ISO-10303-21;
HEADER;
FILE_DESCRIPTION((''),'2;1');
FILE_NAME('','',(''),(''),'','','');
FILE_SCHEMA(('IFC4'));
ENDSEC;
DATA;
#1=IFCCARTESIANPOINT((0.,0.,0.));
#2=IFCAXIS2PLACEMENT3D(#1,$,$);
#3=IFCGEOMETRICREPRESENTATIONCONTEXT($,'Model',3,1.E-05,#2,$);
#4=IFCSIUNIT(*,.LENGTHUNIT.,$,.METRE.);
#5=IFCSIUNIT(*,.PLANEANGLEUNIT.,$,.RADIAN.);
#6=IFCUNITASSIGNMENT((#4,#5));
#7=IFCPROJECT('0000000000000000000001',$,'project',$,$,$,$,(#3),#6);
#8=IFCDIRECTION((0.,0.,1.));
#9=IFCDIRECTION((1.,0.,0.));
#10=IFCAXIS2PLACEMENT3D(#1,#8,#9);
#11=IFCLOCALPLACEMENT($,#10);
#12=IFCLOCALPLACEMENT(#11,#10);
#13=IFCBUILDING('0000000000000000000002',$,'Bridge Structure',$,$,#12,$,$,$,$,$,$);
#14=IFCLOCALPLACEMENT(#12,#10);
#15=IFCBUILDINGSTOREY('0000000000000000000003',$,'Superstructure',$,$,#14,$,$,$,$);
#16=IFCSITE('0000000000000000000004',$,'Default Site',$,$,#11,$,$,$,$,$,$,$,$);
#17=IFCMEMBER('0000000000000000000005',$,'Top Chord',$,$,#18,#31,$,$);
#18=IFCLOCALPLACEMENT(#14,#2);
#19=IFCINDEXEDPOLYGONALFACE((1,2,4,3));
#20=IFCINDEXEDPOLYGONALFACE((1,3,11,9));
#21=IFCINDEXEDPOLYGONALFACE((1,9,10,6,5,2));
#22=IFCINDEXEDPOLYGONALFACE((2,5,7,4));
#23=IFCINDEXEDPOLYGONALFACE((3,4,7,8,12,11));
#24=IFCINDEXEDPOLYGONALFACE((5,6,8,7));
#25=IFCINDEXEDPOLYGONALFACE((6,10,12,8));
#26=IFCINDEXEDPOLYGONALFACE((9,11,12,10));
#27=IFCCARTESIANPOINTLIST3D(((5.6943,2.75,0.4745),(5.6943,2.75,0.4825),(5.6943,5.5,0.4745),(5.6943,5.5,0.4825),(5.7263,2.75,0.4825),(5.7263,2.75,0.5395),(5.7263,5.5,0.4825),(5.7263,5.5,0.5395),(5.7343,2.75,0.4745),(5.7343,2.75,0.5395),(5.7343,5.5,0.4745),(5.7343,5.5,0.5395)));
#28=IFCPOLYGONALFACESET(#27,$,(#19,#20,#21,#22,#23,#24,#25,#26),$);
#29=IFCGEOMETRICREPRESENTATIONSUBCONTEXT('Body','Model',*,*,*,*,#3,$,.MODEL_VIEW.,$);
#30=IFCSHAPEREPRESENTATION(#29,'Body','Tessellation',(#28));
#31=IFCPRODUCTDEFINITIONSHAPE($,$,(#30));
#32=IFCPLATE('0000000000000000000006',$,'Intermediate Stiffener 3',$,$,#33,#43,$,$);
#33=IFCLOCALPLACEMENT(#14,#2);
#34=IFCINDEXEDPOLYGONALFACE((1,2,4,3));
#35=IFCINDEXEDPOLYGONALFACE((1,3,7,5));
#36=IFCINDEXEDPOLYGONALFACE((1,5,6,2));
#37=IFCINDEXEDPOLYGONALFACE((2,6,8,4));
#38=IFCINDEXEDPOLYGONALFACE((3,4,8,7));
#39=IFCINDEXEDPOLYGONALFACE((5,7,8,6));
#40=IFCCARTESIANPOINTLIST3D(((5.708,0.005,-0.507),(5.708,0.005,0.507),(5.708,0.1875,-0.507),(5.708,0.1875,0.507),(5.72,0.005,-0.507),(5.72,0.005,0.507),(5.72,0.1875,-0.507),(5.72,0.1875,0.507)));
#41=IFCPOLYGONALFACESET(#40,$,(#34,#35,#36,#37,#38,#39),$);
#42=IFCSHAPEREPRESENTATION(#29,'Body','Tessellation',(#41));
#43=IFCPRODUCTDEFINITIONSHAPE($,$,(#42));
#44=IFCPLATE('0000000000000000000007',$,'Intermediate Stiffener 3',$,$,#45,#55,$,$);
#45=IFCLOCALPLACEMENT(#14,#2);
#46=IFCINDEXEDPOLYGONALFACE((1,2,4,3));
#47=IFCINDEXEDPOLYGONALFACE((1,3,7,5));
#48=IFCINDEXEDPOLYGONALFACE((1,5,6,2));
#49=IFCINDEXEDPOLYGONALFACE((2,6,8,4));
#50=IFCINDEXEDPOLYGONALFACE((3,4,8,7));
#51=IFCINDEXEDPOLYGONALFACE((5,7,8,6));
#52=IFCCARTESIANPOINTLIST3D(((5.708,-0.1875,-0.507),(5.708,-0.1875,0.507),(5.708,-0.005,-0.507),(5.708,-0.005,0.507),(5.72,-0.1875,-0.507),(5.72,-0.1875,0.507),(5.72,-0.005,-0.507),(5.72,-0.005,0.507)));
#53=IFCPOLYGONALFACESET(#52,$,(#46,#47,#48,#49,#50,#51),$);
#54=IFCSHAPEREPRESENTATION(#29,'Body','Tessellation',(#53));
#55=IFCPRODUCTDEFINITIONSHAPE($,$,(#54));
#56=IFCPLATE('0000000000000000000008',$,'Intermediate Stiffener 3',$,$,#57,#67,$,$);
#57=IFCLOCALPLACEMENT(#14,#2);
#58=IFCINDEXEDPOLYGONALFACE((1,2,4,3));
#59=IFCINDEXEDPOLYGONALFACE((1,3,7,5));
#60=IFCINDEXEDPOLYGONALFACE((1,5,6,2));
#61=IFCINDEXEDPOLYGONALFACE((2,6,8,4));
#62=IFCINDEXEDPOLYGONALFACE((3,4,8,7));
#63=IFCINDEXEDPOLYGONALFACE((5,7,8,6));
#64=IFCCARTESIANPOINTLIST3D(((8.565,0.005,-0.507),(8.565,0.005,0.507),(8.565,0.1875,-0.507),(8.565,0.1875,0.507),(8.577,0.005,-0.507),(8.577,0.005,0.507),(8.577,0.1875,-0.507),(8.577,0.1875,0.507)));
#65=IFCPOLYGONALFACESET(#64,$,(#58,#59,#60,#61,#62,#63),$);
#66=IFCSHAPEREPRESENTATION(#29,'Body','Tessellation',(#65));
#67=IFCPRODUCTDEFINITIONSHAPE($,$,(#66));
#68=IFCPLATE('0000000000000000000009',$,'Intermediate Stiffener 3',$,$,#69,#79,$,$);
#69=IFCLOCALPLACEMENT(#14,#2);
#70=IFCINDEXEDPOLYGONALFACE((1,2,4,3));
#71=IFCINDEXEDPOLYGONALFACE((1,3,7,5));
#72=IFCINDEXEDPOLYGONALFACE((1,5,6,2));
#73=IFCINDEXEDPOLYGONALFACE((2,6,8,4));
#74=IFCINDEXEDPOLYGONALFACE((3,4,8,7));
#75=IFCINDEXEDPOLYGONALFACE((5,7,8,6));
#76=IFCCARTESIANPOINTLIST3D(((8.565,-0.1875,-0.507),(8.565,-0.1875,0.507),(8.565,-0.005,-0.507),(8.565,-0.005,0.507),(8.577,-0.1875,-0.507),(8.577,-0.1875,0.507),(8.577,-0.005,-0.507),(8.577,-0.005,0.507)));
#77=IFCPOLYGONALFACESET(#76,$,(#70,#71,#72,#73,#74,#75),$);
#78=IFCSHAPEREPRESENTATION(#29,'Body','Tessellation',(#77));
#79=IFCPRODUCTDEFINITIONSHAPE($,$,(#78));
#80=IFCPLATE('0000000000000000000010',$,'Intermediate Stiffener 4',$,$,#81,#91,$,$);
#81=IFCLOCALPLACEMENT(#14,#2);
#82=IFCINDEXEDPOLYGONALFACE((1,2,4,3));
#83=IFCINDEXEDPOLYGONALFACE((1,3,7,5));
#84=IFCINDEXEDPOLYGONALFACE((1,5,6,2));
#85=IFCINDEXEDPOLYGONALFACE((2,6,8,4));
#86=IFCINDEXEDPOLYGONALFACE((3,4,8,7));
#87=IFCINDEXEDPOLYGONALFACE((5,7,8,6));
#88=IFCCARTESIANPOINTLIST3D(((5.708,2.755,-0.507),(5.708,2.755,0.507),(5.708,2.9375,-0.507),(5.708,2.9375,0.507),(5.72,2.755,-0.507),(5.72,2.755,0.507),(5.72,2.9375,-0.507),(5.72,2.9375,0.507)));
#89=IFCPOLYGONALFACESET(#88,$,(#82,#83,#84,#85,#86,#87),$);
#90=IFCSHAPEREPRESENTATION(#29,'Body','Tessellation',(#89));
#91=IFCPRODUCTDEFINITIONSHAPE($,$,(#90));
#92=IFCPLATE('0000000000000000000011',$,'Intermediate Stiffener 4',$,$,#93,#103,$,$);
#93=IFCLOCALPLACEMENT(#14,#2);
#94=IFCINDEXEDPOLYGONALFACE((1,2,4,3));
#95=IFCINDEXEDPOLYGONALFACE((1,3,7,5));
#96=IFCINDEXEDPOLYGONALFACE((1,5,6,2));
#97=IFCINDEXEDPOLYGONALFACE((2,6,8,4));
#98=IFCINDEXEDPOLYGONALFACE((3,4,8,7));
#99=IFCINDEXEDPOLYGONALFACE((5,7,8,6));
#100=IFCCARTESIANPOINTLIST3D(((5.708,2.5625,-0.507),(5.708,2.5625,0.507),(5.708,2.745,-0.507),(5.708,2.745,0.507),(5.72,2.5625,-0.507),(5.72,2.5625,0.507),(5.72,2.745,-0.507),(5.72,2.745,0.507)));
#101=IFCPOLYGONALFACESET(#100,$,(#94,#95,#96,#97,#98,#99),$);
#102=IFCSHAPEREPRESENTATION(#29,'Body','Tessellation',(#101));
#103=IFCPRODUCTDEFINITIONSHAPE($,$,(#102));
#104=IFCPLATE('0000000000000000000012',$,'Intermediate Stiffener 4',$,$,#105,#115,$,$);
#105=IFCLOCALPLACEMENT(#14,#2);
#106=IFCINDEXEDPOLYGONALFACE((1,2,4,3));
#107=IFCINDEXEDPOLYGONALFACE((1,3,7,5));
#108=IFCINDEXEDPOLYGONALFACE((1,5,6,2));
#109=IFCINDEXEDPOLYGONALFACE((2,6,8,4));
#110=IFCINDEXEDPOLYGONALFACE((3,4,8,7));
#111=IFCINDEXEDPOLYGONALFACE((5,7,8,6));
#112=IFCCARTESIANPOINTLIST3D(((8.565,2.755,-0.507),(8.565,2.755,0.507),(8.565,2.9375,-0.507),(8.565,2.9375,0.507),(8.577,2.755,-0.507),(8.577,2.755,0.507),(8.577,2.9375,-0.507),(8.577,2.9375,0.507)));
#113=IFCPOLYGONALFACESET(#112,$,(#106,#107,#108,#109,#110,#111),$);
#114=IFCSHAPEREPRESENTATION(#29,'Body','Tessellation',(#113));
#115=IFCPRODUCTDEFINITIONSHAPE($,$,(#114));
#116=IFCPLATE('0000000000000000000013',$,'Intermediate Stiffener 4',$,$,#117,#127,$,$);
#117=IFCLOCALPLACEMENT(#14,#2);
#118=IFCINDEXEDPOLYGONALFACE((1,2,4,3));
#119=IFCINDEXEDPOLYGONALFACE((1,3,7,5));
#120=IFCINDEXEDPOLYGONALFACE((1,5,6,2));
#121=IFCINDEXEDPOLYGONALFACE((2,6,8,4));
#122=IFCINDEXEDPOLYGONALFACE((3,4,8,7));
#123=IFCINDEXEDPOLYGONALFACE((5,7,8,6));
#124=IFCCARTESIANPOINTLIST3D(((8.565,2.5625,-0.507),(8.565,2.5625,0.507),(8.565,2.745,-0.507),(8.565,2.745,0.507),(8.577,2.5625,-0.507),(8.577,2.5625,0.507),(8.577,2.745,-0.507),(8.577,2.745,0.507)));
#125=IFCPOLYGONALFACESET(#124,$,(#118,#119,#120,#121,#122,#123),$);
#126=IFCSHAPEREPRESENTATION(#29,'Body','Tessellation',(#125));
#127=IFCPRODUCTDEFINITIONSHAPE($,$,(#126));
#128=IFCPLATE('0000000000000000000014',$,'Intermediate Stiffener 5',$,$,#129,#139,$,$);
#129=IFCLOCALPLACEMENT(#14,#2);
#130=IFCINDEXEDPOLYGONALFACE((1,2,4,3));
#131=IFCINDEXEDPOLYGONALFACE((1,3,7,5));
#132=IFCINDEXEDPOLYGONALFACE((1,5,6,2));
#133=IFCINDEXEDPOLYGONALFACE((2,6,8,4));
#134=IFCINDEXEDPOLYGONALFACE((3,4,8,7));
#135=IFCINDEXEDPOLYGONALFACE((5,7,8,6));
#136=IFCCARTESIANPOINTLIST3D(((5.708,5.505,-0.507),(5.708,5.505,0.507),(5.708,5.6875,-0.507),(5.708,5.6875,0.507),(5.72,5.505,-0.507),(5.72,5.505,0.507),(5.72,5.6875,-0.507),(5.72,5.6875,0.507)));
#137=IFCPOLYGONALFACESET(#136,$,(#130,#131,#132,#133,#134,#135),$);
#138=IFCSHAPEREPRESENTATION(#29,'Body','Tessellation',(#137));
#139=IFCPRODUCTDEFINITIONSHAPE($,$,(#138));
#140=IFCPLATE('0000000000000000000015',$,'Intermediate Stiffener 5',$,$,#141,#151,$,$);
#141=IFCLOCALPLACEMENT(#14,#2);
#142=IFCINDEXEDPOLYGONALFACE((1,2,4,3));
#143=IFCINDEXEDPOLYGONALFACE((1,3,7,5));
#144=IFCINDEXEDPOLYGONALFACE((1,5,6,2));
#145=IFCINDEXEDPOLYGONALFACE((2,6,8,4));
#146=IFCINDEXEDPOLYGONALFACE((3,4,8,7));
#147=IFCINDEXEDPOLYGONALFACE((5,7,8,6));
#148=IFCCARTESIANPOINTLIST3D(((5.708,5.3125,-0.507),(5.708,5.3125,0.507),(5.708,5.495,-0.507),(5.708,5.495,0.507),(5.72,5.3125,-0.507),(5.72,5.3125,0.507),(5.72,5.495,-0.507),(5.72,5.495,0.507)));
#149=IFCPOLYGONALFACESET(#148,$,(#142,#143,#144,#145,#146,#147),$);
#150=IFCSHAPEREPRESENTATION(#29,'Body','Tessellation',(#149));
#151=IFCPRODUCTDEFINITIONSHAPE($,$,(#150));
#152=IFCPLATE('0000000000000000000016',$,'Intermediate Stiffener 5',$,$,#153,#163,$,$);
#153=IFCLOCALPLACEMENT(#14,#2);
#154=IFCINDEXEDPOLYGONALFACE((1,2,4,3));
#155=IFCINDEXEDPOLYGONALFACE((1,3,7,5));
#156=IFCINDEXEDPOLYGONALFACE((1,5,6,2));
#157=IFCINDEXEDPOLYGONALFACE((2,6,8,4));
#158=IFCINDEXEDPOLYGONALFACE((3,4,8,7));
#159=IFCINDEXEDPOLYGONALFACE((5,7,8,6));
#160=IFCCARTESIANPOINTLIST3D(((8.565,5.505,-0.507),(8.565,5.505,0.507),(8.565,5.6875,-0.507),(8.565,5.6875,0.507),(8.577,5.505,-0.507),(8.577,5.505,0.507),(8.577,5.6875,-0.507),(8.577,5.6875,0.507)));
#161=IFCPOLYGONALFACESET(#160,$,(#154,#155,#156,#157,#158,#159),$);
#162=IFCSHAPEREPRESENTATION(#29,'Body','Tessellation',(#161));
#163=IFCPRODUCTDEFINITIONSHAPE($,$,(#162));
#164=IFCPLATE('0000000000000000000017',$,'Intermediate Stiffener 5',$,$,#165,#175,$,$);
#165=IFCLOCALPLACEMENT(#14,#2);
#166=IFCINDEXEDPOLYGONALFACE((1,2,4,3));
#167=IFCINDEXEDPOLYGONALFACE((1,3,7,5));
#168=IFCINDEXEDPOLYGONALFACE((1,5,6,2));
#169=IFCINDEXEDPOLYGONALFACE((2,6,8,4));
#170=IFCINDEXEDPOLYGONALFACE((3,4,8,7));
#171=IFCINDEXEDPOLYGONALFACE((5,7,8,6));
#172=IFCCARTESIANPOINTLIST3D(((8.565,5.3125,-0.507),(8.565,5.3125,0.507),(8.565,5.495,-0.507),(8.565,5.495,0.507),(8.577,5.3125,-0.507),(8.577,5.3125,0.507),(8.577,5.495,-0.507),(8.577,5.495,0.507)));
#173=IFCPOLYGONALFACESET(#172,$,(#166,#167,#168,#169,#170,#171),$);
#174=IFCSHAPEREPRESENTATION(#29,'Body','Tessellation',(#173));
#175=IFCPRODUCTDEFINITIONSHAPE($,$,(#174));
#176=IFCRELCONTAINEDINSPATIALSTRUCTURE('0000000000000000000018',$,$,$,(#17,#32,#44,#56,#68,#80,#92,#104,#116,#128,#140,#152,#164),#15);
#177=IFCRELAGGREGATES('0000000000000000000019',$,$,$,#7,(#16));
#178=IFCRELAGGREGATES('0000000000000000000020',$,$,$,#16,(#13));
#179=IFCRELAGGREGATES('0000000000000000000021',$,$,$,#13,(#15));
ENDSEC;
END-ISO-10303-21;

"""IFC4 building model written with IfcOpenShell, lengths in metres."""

from ifc_helpers import new_model, si_unit, frame, origin, origin_with_axes, origin_2d_with_axis, place, context, subcontext, project, spatial, rectangle, l_section, extrude, element, save


model = new_model("IFC4")

# Units and contexts
model_context = context("Model", 3, precision=1e-05, world=origin())
body_context = subcontext(model_context, "Body", "Model", "MODEL_VIEW")
ifc_project = project(units=[si_unit("LENGTHUNIT", "METRE"), si_unit("PLANEANGLEUNIT", "RADIAN")], contexts=[model_context])

# Site, building, storey
site_placement = place(None, origin_with_axes())
site = spatial("IfcSite", under=ifc_project, at=site_placement, Name="Default Site")
building_placement = place(site_placement, origin_with_axes())
building = spatial("IfcBuilding", under=site, at=building_placement, Name="Bridge Structure")
storey_placement = place(building_placement, origin_with_axes())
storey = spatial("IfcBuildingStorey", under=building, at=storey_placement, Name="Superstructure")

# Member
for number, where, z_axis, x_axis, name in (
    (1, (5.7143, 2.75, 0.507), (0.0, 1.0, 0.0), (-1.0, 0.0, 0.0), "Top Chord"),
):
    element("IfcMember", number, at=place(storey_placement, frame(where, z_axis=z_axis, x_axis=x_axis)), inside=storey, Name=name, context=body_context, shape_type="SweptSolid", body=[
        extrude(l_section(Depth=0.065, Width=0.04, Thickness=0.008, at=origin_2d_with_axis()), origin_with_axes(), (0.0, 0.0, 1.0), 2.75),
    ])

# Plates
for number, where, z_axis, x_axis, name in (
    (2, (5.714, 0.0963, -0.507), (0.0, 0.0, 1.0), (1.0, 0.0, 0.0), "Intermediate Stiffener 3"),
    (3, (5.714, -0.0963, -0.507), (0.0, 0.0, 1.0), (1.0, 0.0, 0.0), "Intermediate Stiffener 3"),
    (4, (8.571, 0.0963, -0.507), (0.0, 0.0, 1.0), (1.0, 0.0, 0.0), "Intermediate Stiffener 3"),
    (5, (8.571, -0.0963, -0.507), (0.0, 0.0, 1.0), (1.0, 0.0, 0.0), "Intermediate Stiffener 3"),
    (6, (5.714, 2.8462, -0.507), (0.0, 0.0, 1.0), (1.0, 0.0, 0.0), "Intermediate Stiffener 4"),
    (7, (5.714, 2.6538, -0.507), (0.0, 0.0, 1.0), (1.0, 0.0, 0.0), "Intermediate Stiffener 4"),
    (8, (8.571, 2.8462, -0.507), (0.0, 0.0, 1.0), (1.0, 0.0, 0.0), "Intermediate Stiffener 4"),
    (9, (8.571, 2.6538, -0.507), (0.0, 0.0, 1.0), (1.0, 0.0, 0.0), "Intermediate Stiffener 4"),
    (10, (5.714, 5.5963, -0.507), (0.0, 0.0, 1.0), (1.0, 0.0, 0.0), "Intermediate Stiffener 5"),
    (11, (5.714, 5.4038, -0.507), (0.0, 0.0, 1.0), (1.0, 0.0, 0.0), "Intermediate Stiffener 5"),
    (12, (8.571, 5.5963, -0.507), (0.0, 0.0, 1.0), (1.0, 0.0, 0.0), "Intermediate Stiffener 5"),
    (13, (8.571, 5.4038, -0.507), (0.0, 0.0, 1.0), (1.0, 0.0, 0.0), "Intermediate Stiffener 5"),
):
    element("IfcPlate", number, at=place(storey_placement, frame(where, z_axis=z_axis, x_axis=x_axis)), inside=storey, Name=name, context=body_context, shape_type="SweptSolid", body=[
        extrude(rectangle(XDim=0.012, YDim=0.1825, at=origin_2d_with_axis()), origin_with_axes(), (0.0, 0.0, 1.0), 1.014),
    ])

save(model, "model.ifc")
